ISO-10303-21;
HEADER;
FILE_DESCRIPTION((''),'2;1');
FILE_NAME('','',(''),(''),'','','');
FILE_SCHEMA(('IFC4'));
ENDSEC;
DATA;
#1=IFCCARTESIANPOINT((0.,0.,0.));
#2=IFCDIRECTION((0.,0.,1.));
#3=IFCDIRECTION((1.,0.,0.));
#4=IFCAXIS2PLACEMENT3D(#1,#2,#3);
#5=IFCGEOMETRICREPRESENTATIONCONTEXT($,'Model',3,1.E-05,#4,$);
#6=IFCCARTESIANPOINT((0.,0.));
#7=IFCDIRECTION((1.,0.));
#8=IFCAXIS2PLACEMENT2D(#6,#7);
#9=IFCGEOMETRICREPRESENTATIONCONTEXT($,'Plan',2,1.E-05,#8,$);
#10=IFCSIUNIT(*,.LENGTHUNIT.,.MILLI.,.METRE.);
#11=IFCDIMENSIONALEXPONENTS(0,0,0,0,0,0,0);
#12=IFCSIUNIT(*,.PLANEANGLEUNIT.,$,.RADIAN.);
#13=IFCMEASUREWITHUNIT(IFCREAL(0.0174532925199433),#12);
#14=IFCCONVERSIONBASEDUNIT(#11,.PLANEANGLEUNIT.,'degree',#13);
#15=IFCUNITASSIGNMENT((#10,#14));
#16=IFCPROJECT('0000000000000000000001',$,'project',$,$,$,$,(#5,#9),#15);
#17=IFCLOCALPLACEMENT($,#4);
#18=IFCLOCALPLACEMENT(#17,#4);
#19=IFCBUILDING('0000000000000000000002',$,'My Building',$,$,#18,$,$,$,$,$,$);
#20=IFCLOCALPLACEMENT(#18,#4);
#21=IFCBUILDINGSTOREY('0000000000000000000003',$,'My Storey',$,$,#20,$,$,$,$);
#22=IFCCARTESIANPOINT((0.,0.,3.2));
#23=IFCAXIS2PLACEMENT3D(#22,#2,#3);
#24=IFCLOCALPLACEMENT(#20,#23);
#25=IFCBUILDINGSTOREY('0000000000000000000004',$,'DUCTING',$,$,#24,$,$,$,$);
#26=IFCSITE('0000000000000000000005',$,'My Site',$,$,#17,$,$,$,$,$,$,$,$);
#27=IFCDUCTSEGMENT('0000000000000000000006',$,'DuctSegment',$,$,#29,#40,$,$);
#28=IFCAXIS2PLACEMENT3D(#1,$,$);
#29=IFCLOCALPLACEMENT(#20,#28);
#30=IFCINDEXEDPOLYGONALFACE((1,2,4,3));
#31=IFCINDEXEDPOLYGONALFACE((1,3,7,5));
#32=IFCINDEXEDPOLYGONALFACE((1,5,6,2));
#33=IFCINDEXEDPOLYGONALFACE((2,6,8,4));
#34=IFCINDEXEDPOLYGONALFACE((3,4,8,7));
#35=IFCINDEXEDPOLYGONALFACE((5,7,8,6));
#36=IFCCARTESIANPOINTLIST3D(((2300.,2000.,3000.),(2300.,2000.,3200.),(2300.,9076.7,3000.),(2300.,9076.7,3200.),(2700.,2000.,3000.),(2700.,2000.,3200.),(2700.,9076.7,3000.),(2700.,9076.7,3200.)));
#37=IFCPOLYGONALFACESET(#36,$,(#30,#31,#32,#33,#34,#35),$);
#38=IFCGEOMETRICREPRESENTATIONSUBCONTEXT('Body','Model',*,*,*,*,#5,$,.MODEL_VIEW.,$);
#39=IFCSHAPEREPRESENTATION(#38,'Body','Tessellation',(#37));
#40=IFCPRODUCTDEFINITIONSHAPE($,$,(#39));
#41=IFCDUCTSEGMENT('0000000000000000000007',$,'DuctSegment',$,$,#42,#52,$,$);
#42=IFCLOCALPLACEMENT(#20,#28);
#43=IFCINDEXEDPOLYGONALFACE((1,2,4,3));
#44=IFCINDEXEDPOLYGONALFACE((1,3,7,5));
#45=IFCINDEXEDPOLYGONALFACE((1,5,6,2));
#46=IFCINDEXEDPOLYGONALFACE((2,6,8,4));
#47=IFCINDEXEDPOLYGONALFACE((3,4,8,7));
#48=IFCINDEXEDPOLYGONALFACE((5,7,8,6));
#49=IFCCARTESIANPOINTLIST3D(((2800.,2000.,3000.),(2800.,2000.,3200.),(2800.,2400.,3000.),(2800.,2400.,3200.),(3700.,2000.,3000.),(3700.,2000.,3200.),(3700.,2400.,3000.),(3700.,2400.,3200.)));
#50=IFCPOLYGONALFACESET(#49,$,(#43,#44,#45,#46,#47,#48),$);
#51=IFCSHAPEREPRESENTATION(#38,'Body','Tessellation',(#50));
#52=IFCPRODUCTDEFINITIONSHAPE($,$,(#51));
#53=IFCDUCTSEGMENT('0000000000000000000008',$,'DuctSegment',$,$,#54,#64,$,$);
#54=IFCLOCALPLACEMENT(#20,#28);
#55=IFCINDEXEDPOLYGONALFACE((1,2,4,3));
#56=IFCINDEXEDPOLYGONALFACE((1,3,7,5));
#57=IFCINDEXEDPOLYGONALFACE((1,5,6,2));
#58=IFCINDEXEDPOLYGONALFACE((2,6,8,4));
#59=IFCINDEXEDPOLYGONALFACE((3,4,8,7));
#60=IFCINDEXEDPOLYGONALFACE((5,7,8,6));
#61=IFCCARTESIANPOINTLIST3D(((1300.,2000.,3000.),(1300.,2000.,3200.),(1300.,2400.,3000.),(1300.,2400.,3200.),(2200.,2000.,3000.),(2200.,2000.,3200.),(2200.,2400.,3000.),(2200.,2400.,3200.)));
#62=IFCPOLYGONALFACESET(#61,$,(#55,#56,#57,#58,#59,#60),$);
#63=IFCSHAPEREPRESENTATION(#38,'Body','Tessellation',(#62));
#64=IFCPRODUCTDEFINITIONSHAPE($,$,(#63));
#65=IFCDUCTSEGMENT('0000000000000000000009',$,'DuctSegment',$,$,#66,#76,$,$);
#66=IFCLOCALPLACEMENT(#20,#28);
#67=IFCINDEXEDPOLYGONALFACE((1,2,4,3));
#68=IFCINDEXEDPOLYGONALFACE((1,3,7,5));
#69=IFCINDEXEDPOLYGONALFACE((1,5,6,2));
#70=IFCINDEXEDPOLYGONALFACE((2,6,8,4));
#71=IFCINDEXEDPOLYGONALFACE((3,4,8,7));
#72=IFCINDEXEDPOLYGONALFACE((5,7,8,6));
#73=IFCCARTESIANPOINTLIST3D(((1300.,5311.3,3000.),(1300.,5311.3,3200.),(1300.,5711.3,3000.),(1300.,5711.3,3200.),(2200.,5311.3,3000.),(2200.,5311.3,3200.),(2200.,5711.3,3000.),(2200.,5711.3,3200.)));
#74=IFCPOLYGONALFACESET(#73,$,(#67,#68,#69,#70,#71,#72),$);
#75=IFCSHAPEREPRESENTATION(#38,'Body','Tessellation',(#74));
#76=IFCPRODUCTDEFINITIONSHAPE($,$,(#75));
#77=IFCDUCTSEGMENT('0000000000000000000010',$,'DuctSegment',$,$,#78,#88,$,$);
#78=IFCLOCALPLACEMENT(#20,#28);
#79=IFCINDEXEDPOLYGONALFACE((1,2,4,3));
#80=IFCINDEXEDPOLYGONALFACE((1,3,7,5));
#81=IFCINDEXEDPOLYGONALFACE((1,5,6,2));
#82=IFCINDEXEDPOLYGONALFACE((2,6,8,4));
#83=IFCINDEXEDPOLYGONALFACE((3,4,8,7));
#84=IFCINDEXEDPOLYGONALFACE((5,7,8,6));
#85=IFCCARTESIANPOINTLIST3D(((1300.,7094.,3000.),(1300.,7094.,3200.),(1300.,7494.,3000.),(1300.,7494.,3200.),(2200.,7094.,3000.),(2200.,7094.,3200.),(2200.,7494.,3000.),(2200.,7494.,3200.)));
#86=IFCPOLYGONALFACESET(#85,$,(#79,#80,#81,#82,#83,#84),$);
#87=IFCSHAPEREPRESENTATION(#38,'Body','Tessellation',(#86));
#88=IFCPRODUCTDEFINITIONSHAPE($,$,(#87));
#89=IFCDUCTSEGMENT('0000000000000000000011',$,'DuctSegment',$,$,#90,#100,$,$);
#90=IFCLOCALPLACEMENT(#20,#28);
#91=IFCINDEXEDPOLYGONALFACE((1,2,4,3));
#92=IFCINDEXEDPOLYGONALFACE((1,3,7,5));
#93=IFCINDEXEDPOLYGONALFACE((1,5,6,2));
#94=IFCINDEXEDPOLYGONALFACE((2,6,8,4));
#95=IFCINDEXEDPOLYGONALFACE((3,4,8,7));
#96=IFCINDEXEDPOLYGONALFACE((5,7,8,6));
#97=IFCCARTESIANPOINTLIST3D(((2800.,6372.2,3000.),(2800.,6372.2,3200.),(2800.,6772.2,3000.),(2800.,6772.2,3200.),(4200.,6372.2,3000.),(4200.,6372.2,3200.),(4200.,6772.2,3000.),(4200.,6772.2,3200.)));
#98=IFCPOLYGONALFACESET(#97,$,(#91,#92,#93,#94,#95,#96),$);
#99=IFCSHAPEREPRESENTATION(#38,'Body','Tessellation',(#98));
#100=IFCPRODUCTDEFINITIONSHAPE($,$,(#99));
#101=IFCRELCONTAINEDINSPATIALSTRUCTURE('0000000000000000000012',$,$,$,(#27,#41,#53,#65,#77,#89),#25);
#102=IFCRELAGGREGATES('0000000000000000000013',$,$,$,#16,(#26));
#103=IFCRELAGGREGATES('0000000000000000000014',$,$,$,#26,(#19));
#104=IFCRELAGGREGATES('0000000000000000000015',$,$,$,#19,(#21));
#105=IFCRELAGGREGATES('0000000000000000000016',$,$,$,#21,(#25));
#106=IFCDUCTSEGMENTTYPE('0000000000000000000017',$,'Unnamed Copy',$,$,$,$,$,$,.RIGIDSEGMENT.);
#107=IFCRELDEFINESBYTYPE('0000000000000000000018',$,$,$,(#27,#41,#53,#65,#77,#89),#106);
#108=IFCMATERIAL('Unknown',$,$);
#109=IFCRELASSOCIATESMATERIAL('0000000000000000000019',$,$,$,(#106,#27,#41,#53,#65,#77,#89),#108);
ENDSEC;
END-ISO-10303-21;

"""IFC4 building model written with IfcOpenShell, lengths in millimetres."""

from ifc_helpers import new_model, entity, si_unit, converted_unit, frame, origin_with_axes, origin_2d_with_axis, place, context, subcontext, project, spatial, rectangle, extrude, material, material_profile, profile_set, profile_usage, type_object, element, save


model = new_model("IFC4")

# Units and contexts
model_context = context("Model", 3, precision=1e-05, world=origin_with_axes())
plan_context = context("Plan", 2, precision=1e-05, world=origin_2d_with_axis())
body_context = subcontext(model_context, "Body", "Model", "MODEL_VIEW")
ifc_project = project(units=[si_unit("LENGTHUNIT", "METRE", prefix="MILLI"), converted_unit("PLANEANGLEUNIT", "degree", entity("IfcReal", 0.0174532925199433), si_unit("PLANEANGLEUNIT", "RADIAN"), dimensions=[0, 0, 0, 0, 0, 0, 0])], contexts=[model_context, plan_context])

# Site, building, storeys
site_placement = place(None, origin_with_axes())
site = spatial("IfcSite", under=ifc_project, at=site_placement, Name="My Site")
building_placement = place(site_placement, origin_with_axes())
building = spatial("IfcBuilding", under=site, at=building_placement, Name="My Building")
storey_1_placement = place(building_placement, origin_with_axes())
storey_1 = spatial("IfcBuildingStorey", under=building, at=storey_1_placement, Name="My Storey")
storey_2_placement = place(storey_1_placement, frame((0.0, 0.0, 3.2), z_axis=(0.0, 0.0, 1.0), x_axis=(1.0, 0.0, 0.0)))
storey_2 = spatial("IfcBuildingStorey", under=storey_1, at=storey_2_placement, Name="DUCTING")

# Duct segments
ifc_material = material(Name="Unknown")
ifc_material_profile = material_profile(ifc_material, rectangle(XDim=400.0, YDim=200.0))
ifc_profile_set = profile_set([ifc_material_profile])
ifc_profile_usage_1 = profile_usage(ifc_profile_set, cardinal=10)
duct_segment_type = type_object("IfcDuctSegmentType", Name="Unnamed Copy", PredefinedType="RIGIDSEGMENT", material=ifc_profile_set)
duct_segment_1_placement = place(storey_2_placement, frame((2500.0, 2000.0, 3096.8), z_axis=(0.0, 1.0, 0.0), x_axis=(-1.0, 0.0, 0.0)))
element("IfcDuctSegment", 1, at=duct_segment_1_placement, inside=storey_2, type_object=duct_segment_type, material=ifc_profile_usage_1, Name="DuctSegment", context=body_context, shape_type="SweptSolid", body=[
    extrude(rectangle(XDim=400.0, YDim=200.0), origin_with_axes(), (0.0, 0.0, 1.0), 7076.7),
])
ifc_profile_usage_2 = profile_usage(ifc_profile_set, cardinal=10)
duct_segment_2_placement = place(storey_2_placement, frame((2800.0, 2200.0, 3096.8), z_axis=(1.0, 0.0, 0.0), x_axis=(0.0, 1.0, 0.0)))
element("IfcDuctSegment", 2, at=duct_segment_2_placement, inside=storey_2, type_object=duct_segment_type, material=ifc_profile_usage_2, Name="DuctSegment", context=body_context, shape_type="SweptSolid", body=[
    extrude(rectangle(XDim=400.0, YDim=200.0), origin_with_axes(), (0.0, 0.0, 1.0), 900.0),
])
ifc_profile_usage_3 = profile_usage(ifc_profile_set, cardinal=10)
duct_segment_3_placement = place(storey_2_placement, frame((2200.0, 2200.0, 3096.8), z_axis=(-1.0, 0.0, 0.0), x_axis=(0.0, -1.0, 0.0)))
element("IfcDuctSegment", 3, at=duct_segment_3_placement, inside=storey_2, type_object=duct_segment_type, material=ifc_profile_usage_3, Name="DuctSegment", context=body_context, shape_type="SweptSolid", body=[
    extrude(rectangle(XDim=400.0, YDim=200.0), origin_with_axes(), (0.0, 0.0, 1.0), 900.0),
])
ifc_profile_usage_4 = profile_usage(ifc_profile_set, cardinal=10)
duct_segment_4_placement = place(storey_2_placement, frame((2200.0, 5511.3, 3096.8), z_axis=(-1.0, 0.0, 0.0), x_axis=(0.0, -1.0, 0.0)))
element("IfcDuctSegment", 4, at=duct_segment_4_placement, inside=storey_2, type_object=duct_segment_type, material=ifc_profile_usage_4, Name="DuctSegment", context=body_context, shape_type="SweptSolid", body=[
    extrude(rectangle(XDim=400.0, YDim=200.0), origin_with_axes(), (0.0, 0.0, 1.0), 900.0),
])
ifc_profile_usage_5 = profile_usage(ifc_profile_set, cardinal=10)
duct_segment_5_placement = place(storey_2_placement, frame((2200.0, 7294.0, 3096.8), z_axis=(-1.0, 0.0, 0.0), x_axis=(0.0, -1.0, 0.0)))
element("IfcDuctSegment", 5, at=duct_segment_5_placement, inside=storey_2, type_object=duct_segment_type, material=ifc_profile_usage_5, Name="DuctSegment", context=body_context, shape_type="SweptSolid", body=[
    extrude(rectangle(XDim=400.0, YDim=200.0), origin_with_axes(), (0.0, 0.0, 1.0), 900.0),
])
ifc_profile_usage_6 = profile_usage(ifc_profile_set, cardinal=10)
duct_segment_6_placement = place(storey_2_placement, frame((2800.0, 6572.2, 3096.8), z_axis=(1.0, 0.0, 0.0), x_axis=(0.0, 1.0, 0.0)))
element("IfcDuctSegment", 6, at=duct_segment_6_placement, inside=storey_2, type_object=duct_segment_type, material=ifc_profile_usage_6, Name="DuctSegment", context=body_context, shape_type="SweptSolid", body=[
    extrude(rectangle(XDim=400.0, YDim=200.0), origin_with_axes(), (0.0, 0.0, 1.0), 1400.0),
])

save(model, "model.ifc")
